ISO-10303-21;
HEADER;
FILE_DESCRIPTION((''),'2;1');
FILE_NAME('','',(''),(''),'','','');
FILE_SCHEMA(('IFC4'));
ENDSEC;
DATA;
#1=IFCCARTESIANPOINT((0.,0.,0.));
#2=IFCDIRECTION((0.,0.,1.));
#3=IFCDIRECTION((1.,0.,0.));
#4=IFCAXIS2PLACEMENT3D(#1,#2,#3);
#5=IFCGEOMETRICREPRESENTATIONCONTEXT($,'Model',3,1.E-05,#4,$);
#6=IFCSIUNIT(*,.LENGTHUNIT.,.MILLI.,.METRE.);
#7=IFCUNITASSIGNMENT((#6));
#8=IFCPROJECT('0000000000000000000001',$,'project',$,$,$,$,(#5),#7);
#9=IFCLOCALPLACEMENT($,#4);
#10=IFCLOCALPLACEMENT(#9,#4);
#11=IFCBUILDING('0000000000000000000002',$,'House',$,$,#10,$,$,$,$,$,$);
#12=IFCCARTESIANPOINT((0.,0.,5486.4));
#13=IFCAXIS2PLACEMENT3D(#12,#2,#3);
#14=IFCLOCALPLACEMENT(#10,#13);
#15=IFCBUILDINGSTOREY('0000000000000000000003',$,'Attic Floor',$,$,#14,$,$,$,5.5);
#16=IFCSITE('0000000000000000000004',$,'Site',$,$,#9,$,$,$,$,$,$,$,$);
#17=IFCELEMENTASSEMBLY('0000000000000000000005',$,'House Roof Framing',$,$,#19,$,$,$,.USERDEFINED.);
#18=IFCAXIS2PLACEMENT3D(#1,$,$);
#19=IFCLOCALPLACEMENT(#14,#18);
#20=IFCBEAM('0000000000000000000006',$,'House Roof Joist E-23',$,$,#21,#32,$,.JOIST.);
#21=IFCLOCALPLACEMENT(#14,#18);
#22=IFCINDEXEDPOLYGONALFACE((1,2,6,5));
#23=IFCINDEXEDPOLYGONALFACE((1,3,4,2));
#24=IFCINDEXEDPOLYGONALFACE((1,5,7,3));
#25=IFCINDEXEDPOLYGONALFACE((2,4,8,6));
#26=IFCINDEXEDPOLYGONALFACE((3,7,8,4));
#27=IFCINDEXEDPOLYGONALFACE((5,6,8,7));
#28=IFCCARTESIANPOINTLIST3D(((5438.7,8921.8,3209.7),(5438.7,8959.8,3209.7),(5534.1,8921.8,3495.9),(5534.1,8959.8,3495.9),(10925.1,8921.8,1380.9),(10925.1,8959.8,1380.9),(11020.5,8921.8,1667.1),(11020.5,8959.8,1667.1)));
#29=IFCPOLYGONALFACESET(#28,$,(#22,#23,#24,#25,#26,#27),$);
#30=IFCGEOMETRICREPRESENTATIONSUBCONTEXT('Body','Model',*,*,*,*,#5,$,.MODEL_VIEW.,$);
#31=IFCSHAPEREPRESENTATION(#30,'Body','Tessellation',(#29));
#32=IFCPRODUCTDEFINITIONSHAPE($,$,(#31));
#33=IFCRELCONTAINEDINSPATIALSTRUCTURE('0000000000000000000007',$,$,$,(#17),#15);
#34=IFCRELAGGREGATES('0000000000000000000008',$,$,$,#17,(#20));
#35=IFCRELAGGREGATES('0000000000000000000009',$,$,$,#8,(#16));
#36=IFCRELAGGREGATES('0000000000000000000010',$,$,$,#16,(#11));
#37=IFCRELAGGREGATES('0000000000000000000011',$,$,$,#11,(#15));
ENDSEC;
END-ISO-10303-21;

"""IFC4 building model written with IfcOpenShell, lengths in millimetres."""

from ifc_helpers import new_model, si_unit, frame, origin_with_axes, origin_2d, place, context, subcontext, project, spatial, rectangle, extrude, element, aggregate, save


model = new_model("IFC4")

# Units and contexts
model_context = context("Model", 3, precision=1e-05, world=origin_with_axes())
body_context = subcontext(model_context, "Body", "Model", "MODEL_VIEW")
ifc_project = project(units=[si_unit("LENGTHUNIT", "METRE", prefix="MILLI")], contexts=[model_context])

# Site, building, storey
site_placement = place(None, origin_with_axes())
site = spatial("IfcSite", under=ifc_project, at=site_placement, Name="Site")
building_placement = place(site_placement, origin_with_axes())
building = spatial("IfcBuilding", under=site, at=building_placement, Name="House")
storey_placement = place(building_placement, frame((0.0, 0.0, 5486.4), z_axis=(0.0, 0.0, 1.0), x_axis=(1.0, 0.0, 0.0)))
storey = spatial("IfcBuildingStorey", under=building, at=storey_placement, Name="Attic Floor", Elevation=5.5)

# Element assembly, beam
assembly_1_placement = place(storey_placement, frame((0.0, 0.0, -5486.4), z_axis=(0.0, 0.0, 1.0), x_axis=(1.0, 0.0, 0.0)))
assembly_1 = element("IfcElementAssembly", 1, at=assembly_1_placement, inside=storey, Name="House Roof Framing", PredefinedType="USERDEFINED")
beam_1_placement = place(assembly_1_placement, frame((5486.4, 8940.8, 8839.2), z_axis=(0.948683, 0.0, -0.316228), x_axis=(0.0, 1.0, 0.0)))
beam_1 = element("IfcBeam", 2, at=beam_1_placement, Name="House Roof Joist E-23", PredefinedType="JOIST", context=body_context, shape_type="SweptSolid", body=[
    extrude(rectangle(XDim=38.1, YDim=301.6, at=origin_2d()), origin_with_axes(), (0.0, 0.0, 1.0), 5783.2),
])
aggregate(assembly_1, [beam_1])

save(model, "model.ifc")
